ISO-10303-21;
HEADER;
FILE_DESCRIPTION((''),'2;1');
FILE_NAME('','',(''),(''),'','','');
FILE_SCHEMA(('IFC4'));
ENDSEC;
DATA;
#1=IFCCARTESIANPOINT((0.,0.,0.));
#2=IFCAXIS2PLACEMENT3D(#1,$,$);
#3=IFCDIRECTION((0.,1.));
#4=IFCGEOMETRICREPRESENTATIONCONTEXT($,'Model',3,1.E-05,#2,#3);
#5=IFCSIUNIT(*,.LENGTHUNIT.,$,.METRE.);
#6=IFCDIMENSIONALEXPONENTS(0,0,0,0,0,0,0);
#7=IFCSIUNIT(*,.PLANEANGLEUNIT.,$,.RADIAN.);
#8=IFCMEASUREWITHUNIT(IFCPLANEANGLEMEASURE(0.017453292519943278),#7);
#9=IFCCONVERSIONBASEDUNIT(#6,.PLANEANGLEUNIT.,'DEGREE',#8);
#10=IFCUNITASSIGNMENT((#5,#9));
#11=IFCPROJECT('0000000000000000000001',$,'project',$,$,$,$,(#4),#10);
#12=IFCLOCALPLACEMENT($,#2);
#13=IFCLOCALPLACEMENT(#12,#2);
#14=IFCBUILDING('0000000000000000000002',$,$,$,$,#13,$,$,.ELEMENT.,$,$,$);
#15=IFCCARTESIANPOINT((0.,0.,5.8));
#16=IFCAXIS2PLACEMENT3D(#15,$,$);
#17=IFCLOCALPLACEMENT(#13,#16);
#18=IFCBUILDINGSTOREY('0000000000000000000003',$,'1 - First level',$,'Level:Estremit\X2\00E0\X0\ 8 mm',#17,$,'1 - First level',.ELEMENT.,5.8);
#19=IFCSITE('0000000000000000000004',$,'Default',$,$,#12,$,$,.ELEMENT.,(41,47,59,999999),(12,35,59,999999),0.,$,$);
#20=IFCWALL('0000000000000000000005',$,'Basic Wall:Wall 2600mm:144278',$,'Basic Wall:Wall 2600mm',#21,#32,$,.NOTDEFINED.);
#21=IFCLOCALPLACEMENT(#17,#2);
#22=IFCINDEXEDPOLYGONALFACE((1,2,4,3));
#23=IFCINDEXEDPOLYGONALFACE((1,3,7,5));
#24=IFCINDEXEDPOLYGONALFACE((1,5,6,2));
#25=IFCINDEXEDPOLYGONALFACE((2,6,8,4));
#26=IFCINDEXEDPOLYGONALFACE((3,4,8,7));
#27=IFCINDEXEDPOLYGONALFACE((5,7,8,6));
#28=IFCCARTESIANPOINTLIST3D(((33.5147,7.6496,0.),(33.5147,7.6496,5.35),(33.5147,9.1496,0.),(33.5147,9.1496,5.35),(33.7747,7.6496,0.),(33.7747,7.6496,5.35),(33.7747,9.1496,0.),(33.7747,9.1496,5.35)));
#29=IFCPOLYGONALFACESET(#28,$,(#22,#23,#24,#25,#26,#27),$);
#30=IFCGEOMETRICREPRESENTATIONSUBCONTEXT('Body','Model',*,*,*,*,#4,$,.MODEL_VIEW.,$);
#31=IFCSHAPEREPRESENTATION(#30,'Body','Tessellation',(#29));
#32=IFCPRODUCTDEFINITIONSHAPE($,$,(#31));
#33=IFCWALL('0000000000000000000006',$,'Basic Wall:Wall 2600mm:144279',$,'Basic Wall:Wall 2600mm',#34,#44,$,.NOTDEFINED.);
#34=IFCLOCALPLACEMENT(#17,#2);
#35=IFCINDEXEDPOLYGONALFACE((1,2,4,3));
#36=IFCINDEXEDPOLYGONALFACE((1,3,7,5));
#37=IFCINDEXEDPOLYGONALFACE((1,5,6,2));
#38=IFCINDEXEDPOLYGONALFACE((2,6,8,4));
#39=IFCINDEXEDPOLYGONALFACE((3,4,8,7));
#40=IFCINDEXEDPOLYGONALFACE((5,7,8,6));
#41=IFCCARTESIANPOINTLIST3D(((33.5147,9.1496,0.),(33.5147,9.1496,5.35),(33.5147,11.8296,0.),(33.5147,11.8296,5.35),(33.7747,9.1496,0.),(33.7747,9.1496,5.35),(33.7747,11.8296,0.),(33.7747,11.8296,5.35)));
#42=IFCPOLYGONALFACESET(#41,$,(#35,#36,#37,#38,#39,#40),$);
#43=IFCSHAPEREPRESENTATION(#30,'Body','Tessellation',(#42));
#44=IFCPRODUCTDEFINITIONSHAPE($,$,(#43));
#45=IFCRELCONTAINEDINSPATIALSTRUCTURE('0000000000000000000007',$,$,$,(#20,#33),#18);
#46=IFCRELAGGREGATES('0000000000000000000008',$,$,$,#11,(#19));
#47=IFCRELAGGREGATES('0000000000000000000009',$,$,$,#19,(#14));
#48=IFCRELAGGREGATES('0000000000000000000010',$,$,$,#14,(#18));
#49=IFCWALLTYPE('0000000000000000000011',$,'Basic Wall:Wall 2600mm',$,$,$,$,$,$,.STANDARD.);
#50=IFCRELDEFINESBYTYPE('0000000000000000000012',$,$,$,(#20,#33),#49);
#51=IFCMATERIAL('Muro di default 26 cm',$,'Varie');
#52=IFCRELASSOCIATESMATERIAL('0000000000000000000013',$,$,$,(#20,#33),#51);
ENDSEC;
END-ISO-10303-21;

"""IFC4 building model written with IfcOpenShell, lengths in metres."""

from ifc_helpers import new_model, entity, si_unit, converted_unit, direction, frame, origin, place, context, subcontext, project, spatial, indexed_curve, outline, extrude, material, type_object, element, save


model = new_model("IFC4")

# Units and contexts
model_context = context("Model", 3, precision=1e-05, world=origin(), true_north=direction((0.0, 1.0)))
body_context = subcontext(model_context, "Body", "Model", "MODEL_VIEW")
ifc_project = project(units=[si_unit("LENGTHUNIT", "METRE"), converted_unit("PLANEANGLEUNIT", "DEGREE", entity("IfcPlaneAngleMeasure", 0.017453292519943278), si_unit("PLANEANGLEUNIT", "RADIAN"), dimensions=[0, 0, 0, 0, 0, 0, 0])], contexts=[model_context])

# Site, building, storey
site_placement = place(None, origin())
site = spatial("IfcSite", under=ifc_project, at=site_placement, Name="Default", CompositionType="ELEMENT", RefLatitude=(41, 47, 59, 999999), RefLongitude=(12, 35, 59, 999999), RefElevation=0.0)
building_placement = place(site_placement, origin())
building = spatial("IfcBuilding", under=site, at=building_placement, CompositionType="ELEMENT")
storey_placement = place(building_placement, frame((0.0, 0.0, 5.8)))
storey = spatial("IfcBuildingStorey", under=building, at=storey_placement, Name="1 - First level", ObjectType="Level:Estremità 8 mm", LongName="1 - First level", CompositionType="ELEMENT", Elevation=5.8)

# Walls
ifc_material_1 = material(Name="Muro di default 26 cm", Category="Varie")
wall_type_1 = type_object("IfcWallType", Name="Basic Wall:Wall 2600mm", PredefinedType="STANDARD")
wall_1_placement = place(storey_placement, frame((33.6447, 7.6496, 0.0), z_axis=(0.0, 0.0, 1.0), x_axis=(0.0, 1.0, 0.0)))
element("IfcWall", 1, at=wall_1_placement, inside=storey, type_object=wall_type_1, material=ifc_material_1, Name="Basic Wall:Wall 2600mm:144278", ObjectType="Basic Wall:Wall 2600mm", PredefinedType="NOTDEFINED", context=body_context, shape_type="SweptSolid", body=[
    extrude(outline(indexed_curve([(1.5, 0.13), (0.0, 0.13), (0.0, -0.13), (1.5, -0.13), (1.5, 0.13)], self_intersect=False)), origin(), (0.0, 0.0, 1.0), 5.35),
])
wall_2_placement = place(storey_placement, frame((33.6447, 9.1496, 0.0), z_axis=(0.0, 0.0, 1.0), x_axis=(0.0, 1.0, 0.0)))
element("IfcWall", 2, at=wall_2_placement, inside=storey, type_object=wall_type_1, material=ifc_material_1, Name="Basic Wall:Wall 2600mm:144279", ObjectType="Basic Wall:Wall 2600mm", PredefinedType="NOTDEFINED", context=body_context, shape_type="SweptSolid", body=[
    extrude(outline(indexed_curve([(2.68, 0.13), (0.0, 0.13), (0.0, -0.13), (2.68, -0.13), (2.68, 0.13)], self_intersect=False)), origin(), (0.0, 0.0, 1.0), 5.35),
])

save(model, "model.ifc")
